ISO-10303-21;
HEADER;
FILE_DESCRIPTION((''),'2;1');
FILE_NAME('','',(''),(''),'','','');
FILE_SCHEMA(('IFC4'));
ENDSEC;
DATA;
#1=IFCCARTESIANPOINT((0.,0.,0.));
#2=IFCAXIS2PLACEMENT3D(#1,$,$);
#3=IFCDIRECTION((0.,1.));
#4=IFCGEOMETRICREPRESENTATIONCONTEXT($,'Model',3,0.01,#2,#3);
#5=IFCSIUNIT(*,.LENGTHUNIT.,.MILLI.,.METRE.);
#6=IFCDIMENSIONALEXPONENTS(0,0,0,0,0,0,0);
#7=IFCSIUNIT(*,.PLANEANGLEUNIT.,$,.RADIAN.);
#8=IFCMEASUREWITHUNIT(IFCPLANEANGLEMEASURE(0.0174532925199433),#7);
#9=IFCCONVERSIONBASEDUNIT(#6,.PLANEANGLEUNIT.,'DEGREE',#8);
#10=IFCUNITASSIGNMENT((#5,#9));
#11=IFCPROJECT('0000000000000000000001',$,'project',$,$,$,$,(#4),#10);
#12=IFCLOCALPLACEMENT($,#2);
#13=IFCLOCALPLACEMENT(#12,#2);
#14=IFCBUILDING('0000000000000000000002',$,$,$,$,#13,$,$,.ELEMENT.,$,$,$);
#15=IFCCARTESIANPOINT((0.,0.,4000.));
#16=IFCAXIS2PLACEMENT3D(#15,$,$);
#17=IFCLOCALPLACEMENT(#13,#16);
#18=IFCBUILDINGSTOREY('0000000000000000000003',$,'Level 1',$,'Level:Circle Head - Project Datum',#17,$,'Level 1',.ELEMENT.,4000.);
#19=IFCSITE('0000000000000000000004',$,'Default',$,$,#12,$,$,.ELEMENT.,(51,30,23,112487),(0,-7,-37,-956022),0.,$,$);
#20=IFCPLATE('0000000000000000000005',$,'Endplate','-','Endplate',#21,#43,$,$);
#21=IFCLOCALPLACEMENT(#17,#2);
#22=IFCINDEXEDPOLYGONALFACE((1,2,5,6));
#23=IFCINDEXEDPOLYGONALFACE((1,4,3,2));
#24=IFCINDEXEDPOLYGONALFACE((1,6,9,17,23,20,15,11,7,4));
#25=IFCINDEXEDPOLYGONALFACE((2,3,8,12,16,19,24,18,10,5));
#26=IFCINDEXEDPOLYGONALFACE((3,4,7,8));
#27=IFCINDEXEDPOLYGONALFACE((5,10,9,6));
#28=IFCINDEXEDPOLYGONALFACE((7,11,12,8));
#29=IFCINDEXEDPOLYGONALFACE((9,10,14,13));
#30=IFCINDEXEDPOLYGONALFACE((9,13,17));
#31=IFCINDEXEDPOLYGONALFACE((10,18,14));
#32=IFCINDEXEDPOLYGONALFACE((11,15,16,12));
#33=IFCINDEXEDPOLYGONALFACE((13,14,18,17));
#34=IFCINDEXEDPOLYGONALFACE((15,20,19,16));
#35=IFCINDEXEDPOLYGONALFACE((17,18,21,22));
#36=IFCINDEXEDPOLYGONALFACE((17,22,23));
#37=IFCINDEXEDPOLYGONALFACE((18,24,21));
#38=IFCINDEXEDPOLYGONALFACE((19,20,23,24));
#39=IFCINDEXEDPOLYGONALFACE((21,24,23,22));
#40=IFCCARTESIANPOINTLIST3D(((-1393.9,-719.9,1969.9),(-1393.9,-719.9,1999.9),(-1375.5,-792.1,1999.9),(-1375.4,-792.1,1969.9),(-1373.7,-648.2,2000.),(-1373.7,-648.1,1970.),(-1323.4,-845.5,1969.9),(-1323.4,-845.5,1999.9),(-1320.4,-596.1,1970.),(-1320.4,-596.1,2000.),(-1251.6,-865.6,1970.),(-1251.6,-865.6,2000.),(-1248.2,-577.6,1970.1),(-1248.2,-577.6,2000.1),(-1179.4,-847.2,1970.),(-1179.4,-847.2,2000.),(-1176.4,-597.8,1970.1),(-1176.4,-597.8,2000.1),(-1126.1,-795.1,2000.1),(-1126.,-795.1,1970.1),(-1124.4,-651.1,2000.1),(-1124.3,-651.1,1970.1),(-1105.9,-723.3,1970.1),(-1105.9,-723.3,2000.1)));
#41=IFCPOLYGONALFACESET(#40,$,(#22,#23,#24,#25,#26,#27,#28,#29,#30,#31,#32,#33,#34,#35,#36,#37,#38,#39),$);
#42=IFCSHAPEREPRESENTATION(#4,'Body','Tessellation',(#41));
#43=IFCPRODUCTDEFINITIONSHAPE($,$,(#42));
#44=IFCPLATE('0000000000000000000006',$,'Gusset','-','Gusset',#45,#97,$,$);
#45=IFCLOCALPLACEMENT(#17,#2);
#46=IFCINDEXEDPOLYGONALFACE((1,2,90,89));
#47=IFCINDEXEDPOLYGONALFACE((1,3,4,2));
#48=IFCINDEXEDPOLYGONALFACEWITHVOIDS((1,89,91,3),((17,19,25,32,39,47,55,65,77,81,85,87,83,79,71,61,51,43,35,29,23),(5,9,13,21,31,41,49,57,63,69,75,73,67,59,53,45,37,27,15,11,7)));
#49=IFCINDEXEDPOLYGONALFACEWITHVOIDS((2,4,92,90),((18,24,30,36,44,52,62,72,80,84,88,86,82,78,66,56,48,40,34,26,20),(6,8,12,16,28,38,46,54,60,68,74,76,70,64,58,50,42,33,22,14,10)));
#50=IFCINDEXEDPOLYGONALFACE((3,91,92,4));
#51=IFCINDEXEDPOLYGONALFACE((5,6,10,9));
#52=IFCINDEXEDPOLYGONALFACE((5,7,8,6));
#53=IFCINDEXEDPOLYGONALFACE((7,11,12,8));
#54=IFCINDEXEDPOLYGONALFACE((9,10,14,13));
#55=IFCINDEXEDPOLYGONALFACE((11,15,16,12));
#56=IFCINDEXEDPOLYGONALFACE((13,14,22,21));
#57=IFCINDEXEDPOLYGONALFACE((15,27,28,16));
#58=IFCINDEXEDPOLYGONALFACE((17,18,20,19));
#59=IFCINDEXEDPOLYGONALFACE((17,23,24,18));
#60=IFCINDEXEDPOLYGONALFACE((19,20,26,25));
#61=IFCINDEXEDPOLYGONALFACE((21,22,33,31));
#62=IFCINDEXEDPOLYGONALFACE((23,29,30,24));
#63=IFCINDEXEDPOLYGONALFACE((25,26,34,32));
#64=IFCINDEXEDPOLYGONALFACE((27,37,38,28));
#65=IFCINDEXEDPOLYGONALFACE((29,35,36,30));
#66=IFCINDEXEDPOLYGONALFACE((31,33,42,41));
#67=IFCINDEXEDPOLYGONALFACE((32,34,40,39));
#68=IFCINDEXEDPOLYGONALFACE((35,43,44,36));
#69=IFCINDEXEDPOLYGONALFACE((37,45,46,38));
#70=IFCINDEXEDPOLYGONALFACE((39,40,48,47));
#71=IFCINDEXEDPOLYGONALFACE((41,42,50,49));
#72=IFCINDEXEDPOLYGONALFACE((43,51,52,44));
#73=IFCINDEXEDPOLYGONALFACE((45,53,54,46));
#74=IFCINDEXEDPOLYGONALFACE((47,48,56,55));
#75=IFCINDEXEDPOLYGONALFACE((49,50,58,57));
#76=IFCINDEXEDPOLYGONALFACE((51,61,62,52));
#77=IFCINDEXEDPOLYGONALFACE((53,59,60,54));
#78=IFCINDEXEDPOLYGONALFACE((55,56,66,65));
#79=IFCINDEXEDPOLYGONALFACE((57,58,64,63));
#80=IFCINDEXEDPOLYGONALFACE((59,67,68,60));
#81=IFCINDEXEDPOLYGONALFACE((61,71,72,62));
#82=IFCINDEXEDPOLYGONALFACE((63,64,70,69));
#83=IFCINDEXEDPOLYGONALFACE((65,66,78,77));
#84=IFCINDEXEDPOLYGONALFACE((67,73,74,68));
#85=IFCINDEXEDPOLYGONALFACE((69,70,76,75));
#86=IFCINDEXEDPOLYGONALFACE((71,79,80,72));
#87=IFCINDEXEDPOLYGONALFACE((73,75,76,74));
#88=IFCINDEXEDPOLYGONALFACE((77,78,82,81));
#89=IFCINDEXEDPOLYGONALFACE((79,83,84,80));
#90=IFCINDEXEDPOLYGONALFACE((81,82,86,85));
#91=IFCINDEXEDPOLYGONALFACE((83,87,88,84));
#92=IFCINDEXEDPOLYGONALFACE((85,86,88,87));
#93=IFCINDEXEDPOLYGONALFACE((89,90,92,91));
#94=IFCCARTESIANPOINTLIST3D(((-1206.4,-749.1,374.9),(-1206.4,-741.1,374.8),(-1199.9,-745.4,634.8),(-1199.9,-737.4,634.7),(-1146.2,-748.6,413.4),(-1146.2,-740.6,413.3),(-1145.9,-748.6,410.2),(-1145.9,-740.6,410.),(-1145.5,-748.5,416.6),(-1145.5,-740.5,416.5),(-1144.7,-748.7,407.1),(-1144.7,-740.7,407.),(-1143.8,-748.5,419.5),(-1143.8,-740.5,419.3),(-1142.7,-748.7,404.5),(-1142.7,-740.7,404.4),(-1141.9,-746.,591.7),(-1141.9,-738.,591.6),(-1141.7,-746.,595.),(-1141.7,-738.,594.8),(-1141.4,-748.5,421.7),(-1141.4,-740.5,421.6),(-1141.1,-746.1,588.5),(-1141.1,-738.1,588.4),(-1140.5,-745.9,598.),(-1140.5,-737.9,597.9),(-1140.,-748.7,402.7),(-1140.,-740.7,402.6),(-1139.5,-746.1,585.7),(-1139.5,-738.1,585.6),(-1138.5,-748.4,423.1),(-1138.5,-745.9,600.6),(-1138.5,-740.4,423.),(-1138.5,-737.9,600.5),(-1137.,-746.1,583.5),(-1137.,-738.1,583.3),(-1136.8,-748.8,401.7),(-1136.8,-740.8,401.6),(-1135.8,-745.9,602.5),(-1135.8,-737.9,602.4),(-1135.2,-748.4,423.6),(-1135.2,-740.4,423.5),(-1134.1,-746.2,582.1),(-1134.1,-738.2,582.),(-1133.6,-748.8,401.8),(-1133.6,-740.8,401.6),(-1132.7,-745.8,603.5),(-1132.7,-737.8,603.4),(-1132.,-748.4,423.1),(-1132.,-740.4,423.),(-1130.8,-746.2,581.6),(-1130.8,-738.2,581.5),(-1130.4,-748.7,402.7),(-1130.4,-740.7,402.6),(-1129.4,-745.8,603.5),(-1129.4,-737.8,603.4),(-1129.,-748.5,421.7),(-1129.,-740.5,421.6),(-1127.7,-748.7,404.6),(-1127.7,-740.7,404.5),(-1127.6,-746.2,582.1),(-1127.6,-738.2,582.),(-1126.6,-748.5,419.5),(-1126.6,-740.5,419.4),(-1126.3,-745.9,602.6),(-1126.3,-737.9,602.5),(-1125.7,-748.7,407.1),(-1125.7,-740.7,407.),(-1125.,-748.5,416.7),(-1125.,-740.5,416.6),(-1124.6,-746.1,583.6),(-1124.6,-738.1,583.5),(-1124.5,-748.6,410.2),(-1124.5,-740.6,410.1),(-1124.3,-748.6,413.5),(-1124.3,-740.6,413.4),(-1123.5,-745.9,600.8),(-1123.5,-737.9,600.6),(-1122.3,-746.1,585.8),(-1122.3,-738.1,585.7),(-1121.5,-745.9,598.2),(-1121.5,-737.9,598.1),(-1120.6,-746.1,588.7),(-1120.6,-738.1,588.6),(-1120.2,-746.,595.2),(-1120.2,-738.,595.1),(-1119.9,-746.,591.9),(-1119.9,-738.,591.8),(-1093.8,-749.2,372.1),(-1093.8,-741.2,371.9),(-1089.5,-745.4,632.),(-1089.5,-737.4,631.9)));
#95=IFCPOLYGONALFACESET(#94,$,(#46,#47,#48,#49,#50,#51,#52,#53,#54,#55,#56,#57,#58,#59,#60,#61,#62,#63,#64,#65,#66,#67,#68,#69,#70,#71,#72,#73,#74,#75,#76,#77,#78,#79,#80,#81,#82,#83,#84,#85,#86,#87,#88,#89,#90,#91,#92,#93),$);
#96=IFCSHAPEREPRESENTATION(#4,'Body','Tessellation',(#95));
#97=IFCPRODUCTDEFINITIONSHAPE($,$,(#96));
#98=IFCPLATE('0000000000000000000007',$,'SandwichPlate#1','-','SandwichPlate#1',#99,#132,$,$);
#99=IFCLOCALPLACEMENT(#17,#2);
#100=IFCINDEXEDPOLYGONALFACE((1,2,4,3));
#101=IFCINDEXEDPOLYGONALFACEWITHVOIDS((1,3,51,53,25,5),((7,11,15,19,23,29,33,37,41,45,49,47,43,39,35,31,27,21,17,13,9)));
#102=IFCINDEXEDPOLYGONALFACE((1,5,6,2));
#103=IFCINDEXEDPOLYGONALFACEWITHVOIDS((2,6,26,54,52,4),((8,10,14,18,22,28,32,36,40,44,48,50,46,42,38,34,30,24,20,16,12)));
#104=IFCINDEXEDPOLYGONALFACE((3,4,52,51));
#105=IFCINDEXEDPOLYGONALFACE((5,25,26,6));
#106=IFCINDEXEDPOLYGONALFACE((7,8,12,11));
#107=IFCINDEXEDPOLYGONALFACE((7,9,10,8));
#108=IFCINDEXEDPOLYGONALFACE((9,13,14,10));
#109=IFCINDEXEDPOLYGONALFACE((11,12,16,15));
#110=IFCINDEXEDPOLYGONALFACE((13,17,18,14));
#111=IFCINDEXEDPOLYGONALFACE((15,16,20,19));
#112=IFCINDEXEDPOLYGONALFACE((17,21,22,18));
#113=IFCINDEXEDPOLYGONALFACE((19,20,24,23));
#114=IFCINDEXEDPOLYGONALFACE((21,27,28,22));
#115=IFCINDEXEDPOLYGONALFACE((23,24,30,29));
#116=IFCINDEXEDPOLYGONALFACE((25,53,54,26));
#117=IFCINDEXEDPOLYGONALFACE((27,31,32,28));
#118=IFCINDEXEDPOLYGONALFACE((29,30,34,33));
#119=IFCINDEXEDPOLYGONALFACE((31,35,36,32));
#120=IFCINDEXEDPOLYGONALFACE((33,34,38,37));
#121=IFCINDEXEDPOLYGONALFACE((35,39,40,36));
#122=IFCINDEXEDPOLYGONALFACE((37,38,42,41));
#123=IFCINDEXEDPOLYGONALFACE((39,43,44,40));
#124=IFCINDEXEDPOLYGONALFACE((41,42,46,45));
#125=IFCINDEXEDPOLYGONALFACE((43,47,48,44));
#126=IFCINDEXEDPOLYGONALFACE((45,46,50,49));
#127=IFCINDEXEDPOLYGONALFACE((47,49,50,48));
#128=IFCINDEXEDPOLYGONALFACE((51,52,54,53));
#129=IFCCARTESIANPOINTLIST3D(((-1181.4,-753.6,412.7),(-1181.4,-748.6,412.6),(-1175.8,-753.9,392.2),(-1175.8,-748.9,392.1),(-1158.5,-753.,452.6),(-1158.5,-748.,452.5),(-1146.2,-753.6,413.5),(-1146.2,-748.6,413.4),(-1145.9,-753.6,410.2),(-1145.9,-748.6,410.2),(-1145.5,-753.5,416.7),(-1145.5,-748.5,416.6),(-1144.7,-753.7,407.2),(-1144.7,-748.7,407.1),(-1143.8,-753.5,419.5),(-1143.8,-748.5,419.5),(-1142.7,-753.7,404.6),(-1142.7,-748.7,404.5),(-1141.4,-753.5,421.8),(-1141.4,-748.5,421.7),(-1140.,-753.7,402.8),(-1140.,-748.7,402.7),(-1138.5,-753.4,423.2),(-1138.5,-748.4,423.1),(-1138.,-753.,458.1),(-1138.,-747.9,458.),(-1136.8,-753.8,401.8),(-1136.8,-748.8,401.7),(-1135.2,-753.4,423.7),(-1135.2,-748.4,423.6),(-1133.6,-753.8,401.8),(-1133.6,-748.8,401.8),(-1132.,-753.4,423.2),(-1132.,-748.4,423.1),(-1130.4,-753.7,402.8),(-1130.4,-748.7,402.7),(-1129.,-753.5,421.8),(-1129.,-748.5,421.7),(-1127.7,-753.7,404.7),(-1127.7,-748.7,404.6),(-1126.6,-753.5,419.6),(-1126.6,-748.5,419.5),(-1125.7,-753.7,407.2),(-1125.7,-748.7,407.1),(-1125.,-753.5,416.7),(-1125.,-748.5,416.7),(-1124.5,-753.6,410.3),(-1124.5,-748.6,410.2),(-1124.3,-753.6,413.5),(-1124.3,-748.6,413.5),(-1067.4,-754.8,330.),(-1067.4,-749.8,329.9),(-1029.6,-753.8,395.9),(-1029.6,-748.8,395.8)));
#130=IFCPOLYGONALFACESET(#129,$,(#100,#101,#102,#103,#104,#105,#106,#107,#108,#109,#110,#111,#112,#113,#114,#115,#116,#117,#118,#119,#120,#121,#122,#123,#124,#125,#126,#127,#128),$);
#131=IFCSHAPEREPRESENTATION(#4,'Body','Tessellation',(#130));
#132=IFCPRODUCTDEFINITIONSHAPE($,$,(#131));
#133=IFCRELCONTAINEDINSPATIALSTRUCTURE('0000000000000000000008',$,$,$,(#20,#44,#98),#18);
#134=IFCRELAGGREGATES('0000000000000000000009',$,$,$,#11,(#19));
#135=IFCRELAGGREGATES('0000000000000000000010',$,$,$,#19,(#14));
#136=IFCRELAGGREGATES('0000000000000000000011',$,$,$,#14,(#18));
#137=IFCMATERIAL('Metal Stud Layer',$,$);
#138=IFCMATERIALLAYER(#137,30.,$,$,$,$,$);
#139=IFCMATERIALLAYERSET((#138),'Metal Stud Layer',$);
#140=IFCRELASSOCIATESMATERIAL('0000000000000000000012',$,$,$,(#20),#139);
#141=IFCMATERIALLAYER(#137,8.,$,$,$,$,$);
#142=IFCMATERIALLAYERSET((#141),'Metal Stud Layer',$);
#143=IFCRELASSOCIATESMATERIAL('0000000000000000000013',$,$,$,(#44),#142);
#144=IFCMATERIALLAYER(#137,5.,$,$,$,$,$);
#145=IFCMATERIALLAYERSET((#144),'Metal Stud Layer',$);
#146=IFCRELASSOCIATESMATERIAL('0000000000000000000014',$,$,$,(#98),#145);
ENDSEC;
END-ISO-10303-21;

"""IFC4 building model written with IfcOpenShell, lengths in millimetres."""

from ifc_helpers import new_model, entity, si_unit, converted_unit, point, direction, frame, frame_2d, origin, origin_with_axes, origin_2d_with_axis, place, context, project, spatial, polyline, circle_curve, line_curve, trimmed, segment, composite_curve, circle, outline, extrude, material, layer, layer_set, element, save


model = new_model("IFC4")

# Units and contexts
model_context = context("Model", 3, precision=0.01, world=origin(), true_north=direction((0.0, 1.0)))
ifc_project = project(units=[si_unit("LENGTHUNIT", "METRE", prefix="MILLI"), converted_unit("PLANEANGLEUNIT", "DEGREE", entity("IfcPlaneAngleMeasure", 0.0174532925199433), si_unit("PLANEANGLEUNIT", "RADIAN"), dimensions=[0, 0, 0, 0, 0, 0, 0])], contexts=[model_context])

# Site, building, storey
site_placement = place(None, origin())
site = spatial("IfcSite", under=ifc_project, at=site_placement, Name="Default", CompositionType="ELEMENT", RefLatitude=(51, 30, 23, 112487), RefLongitude=(0, -7, -37, -956022), RefElevation=0.0)
building_placement = place(site_placement, origin())
building = spatial("IfcBuilding", under=site, at=building_placement, CompositionType="ELEMENT")
storey_placement = place(building_placement, frame((0.0, 0.0, 4000.0)))
storey = spatial("IfcBuildingStorey", under=building, at=storey_placement, Name="Level 1", ObjectType="Level:Circle Head - Project Datum", LongName="Level 1", CompositionType="ELEMENT", Elevation=4000.0)

# Plates, openings
ifc_material_1 = material(Name="Metal Stud Layer")
ifc_layer_1 = layer(ifc_material_1, 30.0)
ifc_layer_set_1 = layer_set([ifc_layer_1], Name="Metal Stud Layer")
plate_1_placement = place(storey_placement, frame((-1179.4, -847.2, 1970.0), z_axis=(-0.000702, -0.000406, 1.0), x_axis=(0.871905, 0.489674, 0.000811)))
plate_1 = element("IfcPlate", 1, at=plate_1_placement, inside=storey, material=ifc_layer_set_1, Name="Endplate", Description="-", ObjectType="Endplate", context=model_context, shape_type="SweptSolid", body=[
    extrude(outline(polyline([(144.0, 0.0), (144.0, 288.0), (-144.0, 288.0), (-144.0, 0.0), (144.0, 0.0)])), origin_with_axes(), (0.0, 0.0, 1.0), 30.0),
])
opening_1_placement = place(plate_1_placement, frame((0.0, 0.0, 0.0), z_axis=(0.0, 0.0, 1.0), x_axis=(1.0, 0.0, 0.0)))
element("IfcOpeningElement", 2, at=opening_1_placement, cuts=plate_1, ObjectType="Opening", context=model_context, shape_type="SweptSolid", body=[
    extrude(outline(composite_curve([segment(trimmed(line_curve((144.0, 0.0), (0.0, 1.0), 144.0), [point((144.0, 0.0))], [point((144.0, 144.0))], True, "CARTESIAN"), True, "CONTINUOUS"), segment(trimmed(circle_curve(frame_2d((0.0, 144.0), x_axis=(-1.0, 0.0)), 144.0), [point((144.0, 144.0))], [point((0.0, 0.0))], False, "CARTESIAN"), True, "CONTINUOUS"), segment(trimmed(line_curve((0.0, 0.0), (1.0, 0.0), 144.0), [point((0.0, 0.0))], [point((144.0, 0.0))], True, "CARTESIAN"), True, "CONTINUOUS")], self_intersect="UNKNOWN")), origin(), (0.0, 0.0, 1.0), 30.0),
])
opening_2_placement = place(plate_1_placement, frame((0.0, 0.0, 0.0), z_axis=(0.0, 0.0, 1.0), x_axis=(1.0, 0.0, 0.0)))
element("IfcOpeningElement", 3, at=opening_2_placement, cuts=plate_1, ObjectType="Opening", context=model_context, shape_type="SweptSolid", body=[
    extrude(outline(composite_curve([segment(trimmed(line_curve((144.0, 288.0), (-1.0, 0.0), 144.0), [point((144.0, 288.0))], [point((0.0, 288.0))], True, "CARTESIAN"), True, "CONTINUOUS"), segment(trimmed(circle_curve(frame_2d((0.0, 144.0), x_axis=(-1.0, 0.0)), 144.0), [point((0.0, 288.0))], [point((144.0, 144.0))], False, "CARTESIAN"), True, "CONTINUOUS"), segment(trimmed(line_curve((144.0, 144.0), (0.0, 1.0), 144.0), [point((144.0, 144.0))], [point((144.0, 288.0))], True, "CARTESIAN"), True, "CONTINUOUS")], self_intersect="UNKNOWN")), origin(), (0.0, 0.0, 1.0), 30.0),
])
opening_3_placement = place(plate_1_placement, frame((0.0, 0.0, 0.0), z_axis=(0.0, 0.0, 1.0), x_axis=(1.0, 0.0, 0.0)))
element("IfcOpeningElement", 4, at=opening_3_placement, cuts=plate_1, ObjectType="Opening", context=model_context, shape_type="SweptSolid", body=[
    extrude(outline(composite_curve([segment(trimmed(line_curve((-144.0, 288.0), (0.0, -1.0), 144.0), [point((-144.0, 288.0))], [point((-144.0, 144.0))], True, "CARTESIAN"), True, "CONTINUOUS"), segment(trimmed(circle_curve(frame_2d((0.0, 144.0), x_axis=(-1.0, 0.0)), 144.0), [point((-144.0, 144.0))], [point((0.0, 288.0))], False, "CARTESIAN"), True, "CONTINUOUS"), segment(trimmed(line_curve((0.0, 288.0), (-1.0, 0.0), 144.0), [point((0.0, 288.0))], [point((-144.0, 288.0))], True, "CARTESIAN"), True, "CONTINUOUS")], self_intersect="UNKNOWN")), origin(), (0.0, 0.0, 1.0), 30.0),
])
opening_4_placement = place(plate_1_placement, frame((0.0, 0.0, 0.0), z_axis=(0.0, 0.0, 1.0), x_axis=(1.0, 0.0, 0.0)))
element("IfcOpeningElement", 5, at=opening_4_placement, cuts=plate_1, ObjectType="Opening", context=model_context, shape_type="SweptSolid", body=[
    extrude(outline(composite_curve([segment(trimmed(line_curve((-144.0, 0.0), (1.0, 0.0), 144.0), [point((-144.0, 0.0))], [point((0.0, 0.0))], True, "CARTESIAN"), True, "CONTINUOUS"), segment(trimmed(circle_curve(frame_2d((0.0, 144.0), x_axis=(-1.0, 0.0)), 144.0), [point((0.0, 0.0))], [point((-144.0, 144.0))], False, "CARTESIAN"), True, "CONTINUOUS"), segment(trimmed(line_curve((-144.0, 144.0), (0.0, -1.0), 144.0), [point((-144.0, 144.0))], [point((-144.0, 0.0))], True, "CARTESIAN"), True, "CONTINUOUS")], self_intersect="UNKNOWN")), origin(), (0.0, 0.0, 1.0), 30.0),
])
ifc_layer_2 = layer(ifc_material_1, 8.0)
ifc_layer_set_2 = layer_set([ifc_layer_2], Name="Metal Stud Layer")
plate_2_placement = place(storey_placement, frame((-1197.6, -737.4, 634.9), z_axis=(0.0, -0.999896, 0.014432), x_axis=(-0.02499, -0.014428, -0.999584)))
plate_2 = element("IfcPlate", 6, at=plate_2_placement, inside=storey, material=ifc_layer_set_2, Name="Gusset", Description="-", ObjectType="Gusset", context=model_context, shape_type="SweptSolid", body=[
    extrude(outline(polyline([(0.3, -2.3), (260.3, -2.3), (260.3, 110.4), (0.3, 108.2), (0.3, -2.3)])), origin_with_axes(), (0.0, 0.0, 1.0), 8.0),
])
opening_5_placement = place(plate_2_placement, frame((220.8, 68.0, 8.5), z_axis=(0.0, 0.0, -1.0), x_axis=(0.476138, 0.879371, 0.0)))
element("IfcOpeningElement", 7, at=opening_5_placement, cuts=plate_2, ObjectType="Opening", context=model_context, shape_type="SweptSolid", body=[
    extrude(circle(Radius=11.0, at=origin_2d_with_axis()), origin(), (0.0, 0.0, 1.0), 9.0),
])
opening_6_placement = place(plate_2_placement, frame((40.7, 67.8, 8.5), z_axis=(0.0, 0.0, -1.0), x_axis=(-0.530264, 0.847833, 0.0)))
element("IfcOpeningElement", 8, at=opening_6_placement, cuts=plate_2, ObjectType="Opening", context=model_context, shape_type="SweptSolid", body=[
    extrude(circle(Radius=11.0, at=origin_2d_with_axis()), origin(), (0.0, 0.0, 1.0), 9.0),
])
ifc_layer_3 = layer(ifc_material_1, 5.0)
ifc_layer_set_3 = layer_set([ifc_layer_3], Name="Metal Stud Layer")
plate_3_placement = place(storey_placement, frame((-1188.8, -753.8, 399.7), z_axis=(0.0, 0.999896, -0.014432), x_axis=(0.497964, 0.012516, 0.867107)))
plate_3 = element("IfcPlate", 9, at=plate_3_placement, inside=storey, material=ifc_layer_set_3, Name="SandwichPlate#1", Description="-", ObjectType="SandwichPlate#1", context=model_context, shape_type="SweptSolid", body=[
    extrude(outline(polyline([(0.0, 0.0), (76.0, 0.0), (76.0, 140.0), (0.0, 140.0), (0.0, 0.0)])), origin_with_axes(), (0.0, 0.0, 1.0), 5.0),
])
opening_7_placement = place(plate_3_placement, frame((0.0, 0.0, 0.0), z_axis=(0.0, 0.0, 1.0), x_axis=(1.0, 0.0, 0.0)))
element("IfcOpeningElement", 10, at=opening_7_placement, cuts=plate_3, ObjectType="Opening", context=model_context, shape_type="SweptSolid", body=[
    extrude(outline(polyline([(0.0, 0.0), (15.0, 0.0), (0.0, 15.0), (0.0, 0.0)])), origin(), (0.0, 0.0, 1.0), 5.0),
])
opening_8_placement = place(plate_3_placement, frame((0.0, 0.0, 0.0), z_axis=(0.0, 0.0, 1.0), x_axis=(1.0, 0.0, 0.0)))
element("IfcOpeningElement", 11, at=opening_8_placement, cuts=plate_3, ObjectType="Opening", context=model_context, shape_type="SweptSolid", body=[
    extrude(outline(polyline([(76.0, 0.0), (76.0, 15.0), (61.0, 0.0), (76.0, 0.0)])), origin(), (0.0, 0.0, 1.0), 5.0),
])
opening_9_placement = place(plate_3_placement, frame((38.0, 40.0, -0.5), z_axis=(0.0, 0.0, 1.0), x_axis=(0.0, 1.0, 0.0)))
element("IfcOpeningElement", 12, at=opening_9_placement, cuts=plate_3, ObjectType="Opening", context=model_context, shape_type="SweptSolid", body=[
    extrude(circle(Radius=11.0, at=origin_2d_with_axis()), origin(), (0.0, 0.0, 1.0), 6.0),
])

save(model, "model.ifc")
